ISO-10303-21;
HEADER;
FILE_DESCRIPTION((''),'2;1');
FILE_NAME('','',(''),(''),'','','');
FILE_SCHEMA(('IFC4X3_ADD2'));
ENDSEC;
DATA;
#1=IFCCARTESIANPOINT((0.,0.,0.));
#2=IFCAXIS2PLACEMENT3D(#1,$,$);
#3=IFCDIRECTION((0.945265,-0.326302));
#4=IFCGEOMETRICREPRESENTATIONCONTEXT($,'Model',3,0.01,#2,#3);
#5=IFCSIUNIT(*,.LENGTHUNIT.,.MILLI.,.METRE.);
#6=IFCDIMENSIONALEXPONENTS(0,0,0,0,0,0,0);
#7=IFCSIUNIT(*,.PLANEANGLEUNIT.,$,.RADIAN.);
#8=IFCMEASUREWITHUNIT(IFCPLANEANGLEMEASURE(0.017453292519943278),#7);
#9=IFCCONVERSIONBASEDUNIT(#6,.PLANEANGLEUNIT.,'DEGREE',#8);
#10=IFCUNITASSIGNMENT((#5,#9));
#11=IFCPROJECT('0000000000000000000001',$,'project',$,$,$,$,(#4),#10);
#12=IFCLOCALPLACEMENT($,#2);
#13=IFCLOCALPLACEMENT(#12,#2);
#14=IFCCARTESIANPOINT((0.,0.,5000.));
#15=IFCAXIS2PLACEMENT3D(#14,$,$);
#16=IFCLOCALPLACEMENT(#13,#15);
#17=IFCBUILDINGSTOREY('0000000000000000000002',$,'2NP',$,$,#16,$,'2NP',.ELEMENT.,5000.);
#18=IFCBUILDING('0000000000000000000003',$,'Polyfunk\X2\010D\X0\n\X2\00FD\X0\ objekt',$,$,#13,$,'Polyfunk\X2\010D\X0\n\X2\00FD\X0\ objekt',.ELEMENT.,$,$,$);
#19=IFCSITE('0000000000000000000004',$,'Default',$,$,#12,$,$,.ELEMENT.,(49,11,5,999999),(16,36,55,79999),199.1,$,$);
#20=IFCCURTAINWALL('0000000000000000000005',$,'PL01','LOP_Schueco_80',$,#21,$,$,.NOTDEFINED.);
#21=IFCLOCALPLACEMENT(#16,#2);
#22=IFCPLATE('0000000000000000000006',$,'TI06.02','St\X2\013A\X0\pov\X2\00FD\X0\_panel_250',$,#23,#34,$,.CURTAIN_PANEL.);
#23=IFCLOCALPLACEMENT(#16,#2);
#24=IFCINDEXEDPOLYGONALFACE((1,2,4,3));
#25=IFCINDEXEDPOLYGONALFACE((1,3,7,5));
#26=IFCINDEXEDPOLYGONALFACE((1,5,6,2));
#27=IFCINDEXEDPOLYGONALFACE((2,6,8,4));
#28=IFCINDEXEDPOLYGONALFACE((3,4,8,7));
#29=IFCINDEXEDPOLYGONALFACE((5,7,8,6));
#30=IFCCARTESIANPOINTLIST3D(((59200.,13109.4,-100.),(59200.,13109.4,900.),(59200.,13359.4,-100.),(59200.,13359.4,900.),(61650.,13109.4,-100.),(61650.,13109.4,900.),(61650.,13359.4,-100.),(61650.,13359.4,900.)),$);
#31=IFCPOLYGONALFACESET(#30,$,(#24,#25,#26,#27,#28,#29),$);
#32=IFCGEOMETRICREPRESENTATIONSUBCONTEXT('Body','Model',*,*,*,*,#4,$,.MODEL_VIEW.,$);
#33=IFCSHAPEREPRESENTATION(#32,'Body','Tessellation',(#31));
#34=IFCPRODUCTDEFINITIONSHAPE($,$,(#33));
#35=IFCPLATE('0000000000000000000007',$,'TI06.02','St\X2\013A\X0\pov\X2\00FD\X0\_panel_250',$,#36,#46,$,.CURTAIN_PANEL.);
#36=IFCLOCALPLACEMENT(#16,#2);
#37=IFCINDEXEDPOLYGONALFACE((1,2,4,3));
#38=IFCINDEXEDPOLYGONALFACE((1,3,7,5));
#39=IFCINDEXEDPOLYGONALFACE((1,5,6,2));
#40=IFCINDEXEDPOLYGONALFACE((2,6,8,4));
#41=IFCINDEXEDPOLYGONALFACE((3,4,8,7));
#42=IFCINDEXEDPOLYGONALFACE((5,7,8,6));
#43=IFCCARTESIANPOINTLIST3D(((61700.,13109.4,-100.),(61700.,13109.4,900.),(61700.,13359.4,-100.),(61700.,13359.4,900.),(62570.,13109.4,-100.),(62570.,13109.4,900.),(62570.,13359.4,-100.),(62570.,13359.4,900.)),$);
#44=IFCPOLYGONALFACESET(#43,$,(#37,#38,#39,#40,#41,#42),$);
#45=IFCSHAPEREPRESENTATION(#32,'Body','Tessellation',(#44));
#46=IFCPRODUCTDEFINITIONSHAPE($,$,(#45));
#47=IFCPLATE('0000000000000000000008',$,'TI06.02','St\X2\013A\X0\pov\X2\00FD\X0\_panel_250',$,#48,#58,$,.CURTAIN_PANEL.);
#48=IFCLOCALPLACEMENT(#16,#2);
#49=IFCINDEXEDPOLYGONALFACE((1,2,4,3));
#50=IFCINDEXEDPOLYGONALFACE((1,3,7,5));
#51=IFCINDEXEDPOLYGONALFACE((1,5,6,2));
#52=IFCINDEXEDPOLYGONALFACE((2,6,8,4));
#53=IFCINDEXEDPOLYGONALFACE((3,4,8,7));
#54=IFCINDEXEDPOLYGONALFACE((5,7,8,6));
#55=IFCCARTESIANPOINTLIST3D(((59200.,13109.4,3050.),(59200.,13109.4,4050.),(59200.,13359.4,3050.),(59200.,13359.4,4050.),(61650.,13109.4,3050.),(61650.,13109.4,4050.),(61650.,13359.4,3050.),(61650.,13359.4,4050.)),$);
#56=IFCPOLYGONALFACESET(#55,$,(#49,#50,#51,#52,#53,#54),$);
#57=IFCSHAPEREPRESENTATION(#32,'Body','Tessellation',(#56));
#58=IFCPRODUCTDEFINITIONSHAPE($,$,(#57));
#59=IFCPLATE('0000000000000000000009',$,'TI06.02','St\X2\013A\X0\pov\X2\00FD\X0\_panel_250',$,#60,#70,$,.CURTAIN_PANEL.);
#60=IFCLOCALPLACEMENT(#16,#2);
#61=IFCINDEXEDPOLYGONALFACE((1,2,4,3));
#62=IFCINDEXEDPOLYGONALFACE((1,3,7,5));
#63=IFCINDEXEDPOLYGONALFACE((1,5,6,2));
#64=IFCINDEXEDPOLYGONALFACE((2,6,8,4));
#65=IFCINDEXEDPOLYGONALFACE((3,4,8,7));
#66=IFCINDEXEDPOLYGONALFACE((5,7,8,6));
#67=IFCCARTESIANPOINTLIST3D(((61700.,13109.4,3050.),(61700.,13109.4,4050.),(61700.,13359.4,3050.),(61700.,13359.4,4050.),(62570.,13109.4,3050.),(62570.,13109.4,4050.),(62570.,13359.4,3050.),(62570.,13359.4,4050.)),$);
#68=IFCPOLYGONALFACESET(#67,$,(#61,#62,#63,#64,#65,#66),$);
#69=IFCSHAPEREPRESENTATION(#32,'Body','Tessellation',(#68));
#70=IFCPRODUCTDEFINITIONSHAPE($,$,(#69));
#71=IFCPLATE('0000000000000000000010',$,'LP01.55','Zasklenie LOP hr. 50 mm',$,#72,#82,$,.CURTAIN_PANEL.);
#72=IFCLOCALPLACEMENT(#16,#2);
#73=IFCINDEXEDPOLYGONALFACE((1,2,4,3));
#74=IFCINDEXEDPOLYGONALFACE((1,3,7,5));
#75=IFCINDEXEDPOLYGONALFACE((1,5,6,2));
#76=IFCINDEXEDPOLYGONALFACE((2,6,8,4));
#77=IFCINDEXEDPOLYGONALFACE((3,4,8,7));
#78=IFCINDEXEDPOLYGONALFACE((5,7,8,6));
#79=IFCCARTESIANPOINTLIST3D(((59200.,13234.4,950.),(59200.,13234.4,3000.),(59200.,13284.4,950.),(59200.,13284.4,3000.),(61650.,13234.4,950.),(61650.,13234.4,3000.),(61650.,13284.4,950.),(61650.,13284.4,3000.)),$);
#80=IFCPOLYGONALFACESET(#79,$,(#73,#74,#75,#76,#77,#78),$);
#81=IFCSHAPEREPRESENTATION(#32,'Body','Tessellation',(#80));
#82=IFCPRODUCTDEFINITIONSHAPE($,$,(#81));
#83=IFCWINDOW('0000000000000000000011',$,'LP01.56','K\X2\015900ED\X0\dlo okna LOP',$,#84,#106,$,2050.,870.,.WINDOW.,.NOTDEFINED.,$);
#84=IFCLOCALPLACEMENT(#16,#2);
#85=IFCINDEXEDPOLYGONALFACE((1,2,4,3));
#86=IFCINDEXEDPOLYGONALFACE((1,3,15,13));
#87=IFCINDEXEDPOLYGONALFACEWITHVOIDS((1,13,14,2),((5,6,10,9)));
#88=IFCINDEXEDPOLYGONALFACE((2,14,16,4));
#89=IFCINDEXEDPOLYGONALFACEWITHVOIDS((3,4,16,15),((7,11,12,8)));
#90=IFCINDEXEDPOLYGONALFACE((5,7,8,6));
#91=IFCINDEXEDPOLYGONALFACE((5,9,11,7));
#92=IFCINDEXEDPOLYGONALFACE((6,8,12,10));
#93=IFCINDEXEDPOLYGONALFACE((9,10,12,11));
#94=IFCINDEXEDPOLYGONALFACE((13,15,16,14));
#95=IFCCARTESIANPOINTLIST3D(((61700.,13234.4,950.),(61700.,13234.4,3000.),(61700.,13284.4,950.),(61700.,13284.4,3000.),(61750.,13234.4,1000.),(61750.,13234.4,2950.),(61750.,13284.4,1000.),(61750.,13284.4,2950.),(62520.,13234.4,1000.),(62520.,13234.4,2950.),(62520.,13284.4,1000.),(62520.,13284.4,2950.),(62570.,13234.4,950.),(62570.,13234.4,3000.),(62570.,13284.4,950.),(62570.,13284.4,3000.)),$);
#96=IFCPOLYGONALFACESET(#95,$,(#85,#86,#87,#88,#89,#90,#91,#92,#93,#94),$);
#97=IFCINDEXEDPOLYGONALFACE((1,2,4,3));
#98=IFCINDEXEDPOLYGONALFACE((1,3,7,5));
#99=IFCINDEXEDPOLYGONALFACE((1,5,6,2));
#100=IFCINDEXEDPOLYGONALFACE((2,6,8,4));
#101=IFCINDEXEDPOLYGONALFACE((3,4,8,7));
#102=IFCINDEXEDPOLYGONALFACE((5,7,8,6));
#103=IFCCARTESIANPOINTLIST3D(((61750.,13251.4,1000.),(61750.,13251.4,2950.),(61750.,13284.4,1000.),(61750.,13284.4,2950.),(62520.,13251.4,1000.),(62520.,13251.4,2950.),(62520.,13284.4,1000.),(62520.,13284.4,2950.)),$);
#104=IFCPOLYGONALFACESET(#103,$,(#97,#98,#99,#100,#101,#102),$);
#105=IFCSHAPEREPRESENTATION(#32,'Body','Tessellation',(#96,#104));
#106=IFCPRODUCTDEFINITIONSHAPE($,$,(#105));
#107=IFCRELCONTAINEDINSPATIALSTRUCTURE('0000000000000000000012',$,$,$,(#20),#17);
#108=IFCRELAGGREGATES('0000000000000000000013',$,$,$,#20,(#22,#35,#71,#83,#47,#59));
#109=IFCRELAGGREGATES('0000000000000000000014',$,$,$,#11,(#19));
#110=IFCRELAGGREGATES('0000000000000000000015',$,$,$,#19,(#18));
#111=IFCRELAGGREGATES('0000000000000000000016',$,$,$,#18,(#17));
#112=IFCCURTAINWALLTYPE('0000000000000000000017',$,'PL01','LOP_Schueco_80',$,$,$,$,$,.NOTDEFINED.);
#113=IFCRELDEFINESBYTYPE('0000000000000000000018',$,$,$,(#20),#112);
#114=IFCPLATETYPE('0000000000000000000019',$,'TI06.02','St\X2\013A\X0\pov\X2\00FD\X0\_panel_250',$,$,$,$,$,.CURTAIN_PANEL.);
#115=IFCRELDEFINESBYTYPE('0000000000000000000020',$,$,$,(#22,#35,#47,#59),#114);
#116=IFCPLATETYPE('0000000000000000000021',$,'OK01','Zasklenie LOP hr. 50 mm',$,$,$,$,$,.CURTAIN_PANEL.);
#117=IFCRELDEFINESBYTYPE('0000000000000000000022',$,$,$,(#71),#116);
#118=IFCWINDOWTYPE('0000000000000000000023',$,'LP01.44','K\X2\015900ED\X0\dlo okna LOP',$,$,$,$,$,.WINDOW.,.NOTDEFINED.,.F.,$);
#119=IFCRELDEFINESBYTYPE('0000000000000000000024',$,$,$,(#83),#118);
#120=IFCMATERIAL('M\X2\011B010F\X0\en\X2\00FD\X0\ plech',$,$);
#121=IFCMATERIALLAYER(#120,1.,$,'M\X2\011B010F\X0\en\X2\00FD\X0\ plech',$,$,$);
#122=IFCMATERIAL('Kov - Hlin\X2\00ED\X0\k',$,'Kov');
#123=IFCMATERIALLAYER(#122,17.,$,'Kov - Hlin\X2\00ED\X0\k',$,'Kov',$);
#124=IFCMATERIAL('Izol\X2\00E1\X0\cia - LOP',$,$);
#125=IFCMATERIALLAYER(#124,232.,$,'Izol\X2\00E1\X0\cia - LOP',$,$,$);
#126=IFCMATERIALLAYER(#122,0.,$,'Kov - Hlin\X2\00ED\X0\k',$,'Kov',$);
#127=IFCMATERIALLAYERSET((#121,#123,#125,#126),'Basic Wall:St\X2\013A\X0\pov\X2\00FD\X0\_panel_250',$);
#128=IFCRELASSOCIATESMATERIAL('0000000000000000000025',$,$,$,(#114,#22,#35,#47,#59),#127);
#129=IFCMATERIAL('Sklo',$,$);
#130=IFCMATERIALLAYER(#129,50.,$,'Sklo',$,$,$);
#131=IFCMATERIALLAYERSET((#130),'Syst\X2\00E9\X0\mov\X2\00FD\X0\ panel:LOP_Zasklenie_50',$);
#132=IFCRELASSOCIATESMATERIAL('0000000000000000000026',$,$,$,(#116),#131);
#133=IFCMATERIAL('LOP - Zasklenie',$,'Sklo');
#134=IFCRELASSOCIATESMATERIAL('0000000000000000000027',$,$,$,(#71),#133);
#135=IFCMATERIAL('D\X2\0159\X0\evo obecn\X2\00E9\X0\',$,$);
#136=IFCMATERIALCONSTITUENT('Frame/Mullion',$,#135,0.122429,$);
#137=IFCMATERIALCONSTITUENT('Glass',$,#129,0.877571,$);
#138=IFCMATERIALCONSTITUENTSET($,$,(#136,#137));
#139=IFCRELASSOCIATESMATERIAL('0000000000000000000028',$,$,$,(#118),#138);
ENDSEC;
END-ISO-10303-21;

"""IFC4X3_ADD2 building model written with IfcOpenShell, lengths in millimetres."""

from ifc_helpers import new_model, entity, si_unit, converted_unit, direction, frame, frame_2d, origin, origin_2d_with_axis, place, context, subcontext, project, spatial, polyline, rectangle, outline, extrude, source, transform, mapped, material, layer, layer_set, layer_usage, constituent, constituent_set, type_object, type_shapes, element, aggregate, save


model = new_model("IFC4X3_ADD2")

# Units and contexts
model_context = context("Model", 3, precision=0.01, world=origin(), true_north=direction((0.945265, -0.326302)))
body_context = subcontext(model_context, "Body", "Model", "MODEL_VIEW")
ifc_project = project(units=[si_unit("LENGTHUNIT", "METRE", prefix="MILLI"), converted_unit("PLANEANGLEUNIT", "DEGREE", entity("IfcPlaneAngleMeasure", 0.017453292519943278), si_unit("PLANEANGLEUNIT", "RADIAN"), dimensions=[0, 0, 0, 0, 0, 0, 0])], contexts=[model_context])

# Site, building, storey
site_placement = place(None, origin())
site = spatial("IfcSite", under=ifc_project, at=site_placement, Name="Default", CompositionType="ELEMENT", RefLatitude=(49, 11, 5, 999999), RefLongitude=(16, 36, 55, 79999), RefElevation=199.1)
building_placement = place(site_placement, origin())
building = spatial("IfcBuilding", under=site, at=building_placement, Name="Polyfunkčný objekt", LongName="Polyfunkčný objekt", CompositionType="ELEMENT")
storey_placement = place(building_placement, frame((0.0, 0.0, 5000.0)))
storey = spatial("IfcBuildingStorey", under=building, at=storey_placement, Name="2NP", LongName="2NP", CompositionType="ELEMENT", Elevation=5000.0)

# Curtain wall, plates, window
curtain_wall_type = type_object("IfcCurtainWallType", Name="PL01", Description="LOP_Schueco_80", PredefinedType="NOTDEFINED")
curtain_wall_placement = place(storey_placement, frame((0.0, 0.0, -5000.0)))
curtain_wall = element("IfcCurtainWall", 1, at=curtain_wall_placement, inside=storey, type_object=curtain_wall_type, Name="PL01", Description="LOP_Schueco_80", PredefinedType="NOTDEFINED")
ifc_material_1 = material(Name="Měďený plech")
ifc_layer_1 = layer(ifc_material_1, 1.0, Name="Měďený plech")
ifc_material_2 = material(Name="Kov - Hliník", Category="Kov")
ifc_layer_2 = layer(ifc_material_2, 17.0, Name="Kov - Hliník", Category="Kov")
ifc_material_3 = material(Name="Izolácia - LOP")
ifc_layer_3 = layer(ifc_material_3, 232.0, Name="Izolácia - LOP")
ifc_layer_4 = layer(ifc_material_2, 0.0, Name="Kov - Hliník", Category="Kov")
ifc_layer_set_1 = layer_set([ifc_layer_1, ifc_layer_2, ifc_layer_3, ifc_layer_4], Name="Basic Wall:Stĺpový_panel_250")
ifc_layer_usage_1 = layer_usage(ifc_layer_set_1, "AXIS2", "NEGATIVE", 125.0)
plate_type_1 = type_object("IfcPlateType", Name="TI06.02", Description="Stĺpový_panel_250", PredefinedType="CURTAIN_PANEL", material=ifc_layer_set_1)
plate_1_placement = place(storey_placement, frame((59200.0, 13234.4, -100.0)))
plate_1 = element("IfcPlate", 2, at=plate_1_placement, type_object=plate_type_1, material=ifc_layer_usage_1, Name="TI06.02", Description="Stĺpový_panel_250", PredefinedType="CURTAIN_PANEL", context=body_context, shape_type="SweptSolid", body=[
    extrude(rectangle(XDim=250.0, YDim=2450.0, at=frame_2d((0.0, 0.0), x_axis=(1.0, 0.0))), frame((1225.0, 0.0, 0.0), z_axis=(0.0, 0.0, 1.0), x_axis=(0.0, 1.0, 0.0)), (0.0, 0.0, 1.0), 1000.0),
])
ifc_layer_usage_2 = layer_usage(ifc_layer_set_1, "AXIS2", "NEGATIVE", 125.0)
plate_2_placement = place(storey_placement, frame((61700.0, 13234.4, -100.0)))
plate_2 = element("IfcPlate", 3, at=plate_2_placement, type_object=plate_type_1, material=ifc_layer_usage_2, Name="TI06.02", Description="Stĺpový_panel_250", PredefinedType="CURTAIN_PANEL", context=body_context, shape_type="SweptSolid", body=[
    extrude(rectangle(XDim=250.0, YDim=870.0, at=frame_2d((0.0, 0.0), x_axis=(1.0, 0.0))), frame((435.0, 0.0, 0.0), z_axis=(0.0, 0.0, 1.0), x_axis=(0.0, 1.0, 0.0)), (0.0, 0.0, 1.0), 1000.0),
])
ifc_layer_usage_3 = layer_usage(ifc_layer_set_1, "AXIS2", "NEGATIVE", 125.0)
plate_3_placement = place(storey_placement, frame((59200.0, 13234.4, 3050.0)))
plate_3 = element("IfcPlate", 4, at=plate_3_placement, type_object=plate_type_1, material=ifc_layer_usage_3, Name="TI06.02", Description="Stĺpový_panel_250", PredefinedType="CURTAIN_PANEL", context=body_context, shape_type="SweptSolid", body=[
    extrude(rectangle(XDim=250.0, YDim=2450.0, at=frame_2d((0.0, 0.0), x_axis=(1.0, 0.0))), frame((1225.0, 0.0, 0.0), z_axis=(0.0, 0.0, 1.0), x_axis=(0.0, 1.0, 0.0)), (0.0, 0.0, 1.0), 1000.0),
])
ifc_layer_usage_4 = layer_usage(ifc_layer_set_1, "AXIS2", "NEGATIVE", 125.0)
plate_4_placement = place(storey_placement, frame((61700.0, 13234.4, 3050.0)))
plate_4 = element("IfcPlate", 5, at=plate_4_placement, type_object=plate_type_1, material=ifc_layer_usage_4, Name="TI06.02", Description="Stĺpový_panel_250", PredefinedType="CURTAIN_PANEL", context=body_context, shape_type="SweptSolid", body=[
    extrude(rectangle(XDim=250.0, YDim=870.0, at=frame_2d((0.0, 0.0), x_axis=(1.0, 0.0))), frame((435.0, 0.0, 0.0), z_axis=(0.0, 0.0, 1.0), x_axis=(0.0, 1.0, 0.0)), (0.0, 0.0, 1.0), 1000.0),
])
ifc_material_4 = material(Name="LOP - Zasklenie", Category="Sklo")
ifc_material_5 = material(Name="Sklo")
ifc_layer_5 = layer(ifc_material_5, 50.0, Name="Sklo")
ifc_layer_set_2 = layer_set([ifc_layer_5], Name="Systémový panel:LOP_Zasklenie_50")
plate_type_2 = type_object("IfcPlateType", Name="OK01", Description="Zasklenie LOP hr. 50 mm", PredefinedType="CURTAIN_PANEL", material=ifc_layer_set_2)
shared_shape_1 = source(origin(), body_context, "Body", "SweptSolid", [
    extrude(rectangle(XDim=50.0, YDim=2450.0, at=origin_2d_with_axis()), frame((0.0, 25.0, 0.0), z_axis=(0.0, 0.0, 1.0), x_axis=(0.0, 1.0, 0.0)), (0.0, 0.0, 1.0), 2050.0),
])
type_shapes(plate_type_2, [shared_shape_1])
plate_5_placement = place(curtain_wall_placement, frame((60425.0, 13234.4, 5950.0)))
plate_5 = element("IfcPlate", 6, at=plate_5_placement, type_object=plate_type_2, material=ifc_material_4, Name="LP01.55", Description="Zasklenie LOP hr. 50 mm", PredefinedType="CURTAIN_PANEL", context=body_context, shape_type="MappedRepresentation", body=[
    mapped(shared_shape_1, transform((0.0, 0.0, 0.0), scale=1.0)),
])
ifc_material_6 = material(Name="Dřevo obecné")
ifc_constituent_1 = constituent(ifc_material_6, Name="Frame/Mullion", fraction=0.122429)
ifc_constituent_2 = constituent(ifc_material_5, Name="Glass", fraction=0.877571)
ifc_constituent_set = constituent_set(constituents=[ifc_constituent_1, ifc_constituent_2])
window_type = type_object("IfcWindowType", Name="LP01.44", Description="Křídlo okna LOP", ParameterTakesPrecedence=False, PartitioningType="NOTDEFINED", PredefinedType="WINDOW", material=ifc_constituent_set)
shared_shape_2 = source(origin(), body_context, "Body", "SweptSolid", [
    extrude(outline(polyline([(-1025.0, -435.0), (1025.0, -435.0), (1025.0, 435.0), (-1025.0, 435.0), (-1025.0, -435.0)]), holes=[polyline([(-975.0, -385.0), (-975.0, 385.0), (975.0, 385.0), (975.0, -385.0), (-975.0, -385.0)])]), frame((0.0, 0.0, 1025.0), z_axis=(0.0, 1.0, 0.0), x_axis=(0.0, 0.0, -1.0)), (0.0, 0.0, 1.0), 50.0),
    extrude(rectangle(XDim=33.0, YDim=770.0, at=origin_2d_with_axis()), frame((0.0, 33.5, 50.0), z_axis=(0.0, 0.0, 1.0), x_axis=(0.0, -1.0, 0.0)), (0.0, 0.0, 1.0), 1950.0),
])
type_shapes(window_type, [shared_shape_2])
window_placement = place(curtain_wall_placement, frame((62135.0, 13234.4, 5950.0)))
window = element("IfcWindow", 7, at=window_placement, type_object=window_type, Name="LP01.56", Description="Křídlo okna LOP", OverallHeight=2050.0, OverallWidth=870.0, PartitioningType="NOTDEFINED", PredefinedType="WINDOW", context=body_context, shape_type="MappedRepresentation", body=[
    mapped(shared_shape_2, transform((0.0, 0.0, 0.0), scale=1.0)),
])
aggregate(curtain_wall, [plate_1, plate_2, plate_5, window, plate_3, plate_4])

save(model, "model.ifc")
